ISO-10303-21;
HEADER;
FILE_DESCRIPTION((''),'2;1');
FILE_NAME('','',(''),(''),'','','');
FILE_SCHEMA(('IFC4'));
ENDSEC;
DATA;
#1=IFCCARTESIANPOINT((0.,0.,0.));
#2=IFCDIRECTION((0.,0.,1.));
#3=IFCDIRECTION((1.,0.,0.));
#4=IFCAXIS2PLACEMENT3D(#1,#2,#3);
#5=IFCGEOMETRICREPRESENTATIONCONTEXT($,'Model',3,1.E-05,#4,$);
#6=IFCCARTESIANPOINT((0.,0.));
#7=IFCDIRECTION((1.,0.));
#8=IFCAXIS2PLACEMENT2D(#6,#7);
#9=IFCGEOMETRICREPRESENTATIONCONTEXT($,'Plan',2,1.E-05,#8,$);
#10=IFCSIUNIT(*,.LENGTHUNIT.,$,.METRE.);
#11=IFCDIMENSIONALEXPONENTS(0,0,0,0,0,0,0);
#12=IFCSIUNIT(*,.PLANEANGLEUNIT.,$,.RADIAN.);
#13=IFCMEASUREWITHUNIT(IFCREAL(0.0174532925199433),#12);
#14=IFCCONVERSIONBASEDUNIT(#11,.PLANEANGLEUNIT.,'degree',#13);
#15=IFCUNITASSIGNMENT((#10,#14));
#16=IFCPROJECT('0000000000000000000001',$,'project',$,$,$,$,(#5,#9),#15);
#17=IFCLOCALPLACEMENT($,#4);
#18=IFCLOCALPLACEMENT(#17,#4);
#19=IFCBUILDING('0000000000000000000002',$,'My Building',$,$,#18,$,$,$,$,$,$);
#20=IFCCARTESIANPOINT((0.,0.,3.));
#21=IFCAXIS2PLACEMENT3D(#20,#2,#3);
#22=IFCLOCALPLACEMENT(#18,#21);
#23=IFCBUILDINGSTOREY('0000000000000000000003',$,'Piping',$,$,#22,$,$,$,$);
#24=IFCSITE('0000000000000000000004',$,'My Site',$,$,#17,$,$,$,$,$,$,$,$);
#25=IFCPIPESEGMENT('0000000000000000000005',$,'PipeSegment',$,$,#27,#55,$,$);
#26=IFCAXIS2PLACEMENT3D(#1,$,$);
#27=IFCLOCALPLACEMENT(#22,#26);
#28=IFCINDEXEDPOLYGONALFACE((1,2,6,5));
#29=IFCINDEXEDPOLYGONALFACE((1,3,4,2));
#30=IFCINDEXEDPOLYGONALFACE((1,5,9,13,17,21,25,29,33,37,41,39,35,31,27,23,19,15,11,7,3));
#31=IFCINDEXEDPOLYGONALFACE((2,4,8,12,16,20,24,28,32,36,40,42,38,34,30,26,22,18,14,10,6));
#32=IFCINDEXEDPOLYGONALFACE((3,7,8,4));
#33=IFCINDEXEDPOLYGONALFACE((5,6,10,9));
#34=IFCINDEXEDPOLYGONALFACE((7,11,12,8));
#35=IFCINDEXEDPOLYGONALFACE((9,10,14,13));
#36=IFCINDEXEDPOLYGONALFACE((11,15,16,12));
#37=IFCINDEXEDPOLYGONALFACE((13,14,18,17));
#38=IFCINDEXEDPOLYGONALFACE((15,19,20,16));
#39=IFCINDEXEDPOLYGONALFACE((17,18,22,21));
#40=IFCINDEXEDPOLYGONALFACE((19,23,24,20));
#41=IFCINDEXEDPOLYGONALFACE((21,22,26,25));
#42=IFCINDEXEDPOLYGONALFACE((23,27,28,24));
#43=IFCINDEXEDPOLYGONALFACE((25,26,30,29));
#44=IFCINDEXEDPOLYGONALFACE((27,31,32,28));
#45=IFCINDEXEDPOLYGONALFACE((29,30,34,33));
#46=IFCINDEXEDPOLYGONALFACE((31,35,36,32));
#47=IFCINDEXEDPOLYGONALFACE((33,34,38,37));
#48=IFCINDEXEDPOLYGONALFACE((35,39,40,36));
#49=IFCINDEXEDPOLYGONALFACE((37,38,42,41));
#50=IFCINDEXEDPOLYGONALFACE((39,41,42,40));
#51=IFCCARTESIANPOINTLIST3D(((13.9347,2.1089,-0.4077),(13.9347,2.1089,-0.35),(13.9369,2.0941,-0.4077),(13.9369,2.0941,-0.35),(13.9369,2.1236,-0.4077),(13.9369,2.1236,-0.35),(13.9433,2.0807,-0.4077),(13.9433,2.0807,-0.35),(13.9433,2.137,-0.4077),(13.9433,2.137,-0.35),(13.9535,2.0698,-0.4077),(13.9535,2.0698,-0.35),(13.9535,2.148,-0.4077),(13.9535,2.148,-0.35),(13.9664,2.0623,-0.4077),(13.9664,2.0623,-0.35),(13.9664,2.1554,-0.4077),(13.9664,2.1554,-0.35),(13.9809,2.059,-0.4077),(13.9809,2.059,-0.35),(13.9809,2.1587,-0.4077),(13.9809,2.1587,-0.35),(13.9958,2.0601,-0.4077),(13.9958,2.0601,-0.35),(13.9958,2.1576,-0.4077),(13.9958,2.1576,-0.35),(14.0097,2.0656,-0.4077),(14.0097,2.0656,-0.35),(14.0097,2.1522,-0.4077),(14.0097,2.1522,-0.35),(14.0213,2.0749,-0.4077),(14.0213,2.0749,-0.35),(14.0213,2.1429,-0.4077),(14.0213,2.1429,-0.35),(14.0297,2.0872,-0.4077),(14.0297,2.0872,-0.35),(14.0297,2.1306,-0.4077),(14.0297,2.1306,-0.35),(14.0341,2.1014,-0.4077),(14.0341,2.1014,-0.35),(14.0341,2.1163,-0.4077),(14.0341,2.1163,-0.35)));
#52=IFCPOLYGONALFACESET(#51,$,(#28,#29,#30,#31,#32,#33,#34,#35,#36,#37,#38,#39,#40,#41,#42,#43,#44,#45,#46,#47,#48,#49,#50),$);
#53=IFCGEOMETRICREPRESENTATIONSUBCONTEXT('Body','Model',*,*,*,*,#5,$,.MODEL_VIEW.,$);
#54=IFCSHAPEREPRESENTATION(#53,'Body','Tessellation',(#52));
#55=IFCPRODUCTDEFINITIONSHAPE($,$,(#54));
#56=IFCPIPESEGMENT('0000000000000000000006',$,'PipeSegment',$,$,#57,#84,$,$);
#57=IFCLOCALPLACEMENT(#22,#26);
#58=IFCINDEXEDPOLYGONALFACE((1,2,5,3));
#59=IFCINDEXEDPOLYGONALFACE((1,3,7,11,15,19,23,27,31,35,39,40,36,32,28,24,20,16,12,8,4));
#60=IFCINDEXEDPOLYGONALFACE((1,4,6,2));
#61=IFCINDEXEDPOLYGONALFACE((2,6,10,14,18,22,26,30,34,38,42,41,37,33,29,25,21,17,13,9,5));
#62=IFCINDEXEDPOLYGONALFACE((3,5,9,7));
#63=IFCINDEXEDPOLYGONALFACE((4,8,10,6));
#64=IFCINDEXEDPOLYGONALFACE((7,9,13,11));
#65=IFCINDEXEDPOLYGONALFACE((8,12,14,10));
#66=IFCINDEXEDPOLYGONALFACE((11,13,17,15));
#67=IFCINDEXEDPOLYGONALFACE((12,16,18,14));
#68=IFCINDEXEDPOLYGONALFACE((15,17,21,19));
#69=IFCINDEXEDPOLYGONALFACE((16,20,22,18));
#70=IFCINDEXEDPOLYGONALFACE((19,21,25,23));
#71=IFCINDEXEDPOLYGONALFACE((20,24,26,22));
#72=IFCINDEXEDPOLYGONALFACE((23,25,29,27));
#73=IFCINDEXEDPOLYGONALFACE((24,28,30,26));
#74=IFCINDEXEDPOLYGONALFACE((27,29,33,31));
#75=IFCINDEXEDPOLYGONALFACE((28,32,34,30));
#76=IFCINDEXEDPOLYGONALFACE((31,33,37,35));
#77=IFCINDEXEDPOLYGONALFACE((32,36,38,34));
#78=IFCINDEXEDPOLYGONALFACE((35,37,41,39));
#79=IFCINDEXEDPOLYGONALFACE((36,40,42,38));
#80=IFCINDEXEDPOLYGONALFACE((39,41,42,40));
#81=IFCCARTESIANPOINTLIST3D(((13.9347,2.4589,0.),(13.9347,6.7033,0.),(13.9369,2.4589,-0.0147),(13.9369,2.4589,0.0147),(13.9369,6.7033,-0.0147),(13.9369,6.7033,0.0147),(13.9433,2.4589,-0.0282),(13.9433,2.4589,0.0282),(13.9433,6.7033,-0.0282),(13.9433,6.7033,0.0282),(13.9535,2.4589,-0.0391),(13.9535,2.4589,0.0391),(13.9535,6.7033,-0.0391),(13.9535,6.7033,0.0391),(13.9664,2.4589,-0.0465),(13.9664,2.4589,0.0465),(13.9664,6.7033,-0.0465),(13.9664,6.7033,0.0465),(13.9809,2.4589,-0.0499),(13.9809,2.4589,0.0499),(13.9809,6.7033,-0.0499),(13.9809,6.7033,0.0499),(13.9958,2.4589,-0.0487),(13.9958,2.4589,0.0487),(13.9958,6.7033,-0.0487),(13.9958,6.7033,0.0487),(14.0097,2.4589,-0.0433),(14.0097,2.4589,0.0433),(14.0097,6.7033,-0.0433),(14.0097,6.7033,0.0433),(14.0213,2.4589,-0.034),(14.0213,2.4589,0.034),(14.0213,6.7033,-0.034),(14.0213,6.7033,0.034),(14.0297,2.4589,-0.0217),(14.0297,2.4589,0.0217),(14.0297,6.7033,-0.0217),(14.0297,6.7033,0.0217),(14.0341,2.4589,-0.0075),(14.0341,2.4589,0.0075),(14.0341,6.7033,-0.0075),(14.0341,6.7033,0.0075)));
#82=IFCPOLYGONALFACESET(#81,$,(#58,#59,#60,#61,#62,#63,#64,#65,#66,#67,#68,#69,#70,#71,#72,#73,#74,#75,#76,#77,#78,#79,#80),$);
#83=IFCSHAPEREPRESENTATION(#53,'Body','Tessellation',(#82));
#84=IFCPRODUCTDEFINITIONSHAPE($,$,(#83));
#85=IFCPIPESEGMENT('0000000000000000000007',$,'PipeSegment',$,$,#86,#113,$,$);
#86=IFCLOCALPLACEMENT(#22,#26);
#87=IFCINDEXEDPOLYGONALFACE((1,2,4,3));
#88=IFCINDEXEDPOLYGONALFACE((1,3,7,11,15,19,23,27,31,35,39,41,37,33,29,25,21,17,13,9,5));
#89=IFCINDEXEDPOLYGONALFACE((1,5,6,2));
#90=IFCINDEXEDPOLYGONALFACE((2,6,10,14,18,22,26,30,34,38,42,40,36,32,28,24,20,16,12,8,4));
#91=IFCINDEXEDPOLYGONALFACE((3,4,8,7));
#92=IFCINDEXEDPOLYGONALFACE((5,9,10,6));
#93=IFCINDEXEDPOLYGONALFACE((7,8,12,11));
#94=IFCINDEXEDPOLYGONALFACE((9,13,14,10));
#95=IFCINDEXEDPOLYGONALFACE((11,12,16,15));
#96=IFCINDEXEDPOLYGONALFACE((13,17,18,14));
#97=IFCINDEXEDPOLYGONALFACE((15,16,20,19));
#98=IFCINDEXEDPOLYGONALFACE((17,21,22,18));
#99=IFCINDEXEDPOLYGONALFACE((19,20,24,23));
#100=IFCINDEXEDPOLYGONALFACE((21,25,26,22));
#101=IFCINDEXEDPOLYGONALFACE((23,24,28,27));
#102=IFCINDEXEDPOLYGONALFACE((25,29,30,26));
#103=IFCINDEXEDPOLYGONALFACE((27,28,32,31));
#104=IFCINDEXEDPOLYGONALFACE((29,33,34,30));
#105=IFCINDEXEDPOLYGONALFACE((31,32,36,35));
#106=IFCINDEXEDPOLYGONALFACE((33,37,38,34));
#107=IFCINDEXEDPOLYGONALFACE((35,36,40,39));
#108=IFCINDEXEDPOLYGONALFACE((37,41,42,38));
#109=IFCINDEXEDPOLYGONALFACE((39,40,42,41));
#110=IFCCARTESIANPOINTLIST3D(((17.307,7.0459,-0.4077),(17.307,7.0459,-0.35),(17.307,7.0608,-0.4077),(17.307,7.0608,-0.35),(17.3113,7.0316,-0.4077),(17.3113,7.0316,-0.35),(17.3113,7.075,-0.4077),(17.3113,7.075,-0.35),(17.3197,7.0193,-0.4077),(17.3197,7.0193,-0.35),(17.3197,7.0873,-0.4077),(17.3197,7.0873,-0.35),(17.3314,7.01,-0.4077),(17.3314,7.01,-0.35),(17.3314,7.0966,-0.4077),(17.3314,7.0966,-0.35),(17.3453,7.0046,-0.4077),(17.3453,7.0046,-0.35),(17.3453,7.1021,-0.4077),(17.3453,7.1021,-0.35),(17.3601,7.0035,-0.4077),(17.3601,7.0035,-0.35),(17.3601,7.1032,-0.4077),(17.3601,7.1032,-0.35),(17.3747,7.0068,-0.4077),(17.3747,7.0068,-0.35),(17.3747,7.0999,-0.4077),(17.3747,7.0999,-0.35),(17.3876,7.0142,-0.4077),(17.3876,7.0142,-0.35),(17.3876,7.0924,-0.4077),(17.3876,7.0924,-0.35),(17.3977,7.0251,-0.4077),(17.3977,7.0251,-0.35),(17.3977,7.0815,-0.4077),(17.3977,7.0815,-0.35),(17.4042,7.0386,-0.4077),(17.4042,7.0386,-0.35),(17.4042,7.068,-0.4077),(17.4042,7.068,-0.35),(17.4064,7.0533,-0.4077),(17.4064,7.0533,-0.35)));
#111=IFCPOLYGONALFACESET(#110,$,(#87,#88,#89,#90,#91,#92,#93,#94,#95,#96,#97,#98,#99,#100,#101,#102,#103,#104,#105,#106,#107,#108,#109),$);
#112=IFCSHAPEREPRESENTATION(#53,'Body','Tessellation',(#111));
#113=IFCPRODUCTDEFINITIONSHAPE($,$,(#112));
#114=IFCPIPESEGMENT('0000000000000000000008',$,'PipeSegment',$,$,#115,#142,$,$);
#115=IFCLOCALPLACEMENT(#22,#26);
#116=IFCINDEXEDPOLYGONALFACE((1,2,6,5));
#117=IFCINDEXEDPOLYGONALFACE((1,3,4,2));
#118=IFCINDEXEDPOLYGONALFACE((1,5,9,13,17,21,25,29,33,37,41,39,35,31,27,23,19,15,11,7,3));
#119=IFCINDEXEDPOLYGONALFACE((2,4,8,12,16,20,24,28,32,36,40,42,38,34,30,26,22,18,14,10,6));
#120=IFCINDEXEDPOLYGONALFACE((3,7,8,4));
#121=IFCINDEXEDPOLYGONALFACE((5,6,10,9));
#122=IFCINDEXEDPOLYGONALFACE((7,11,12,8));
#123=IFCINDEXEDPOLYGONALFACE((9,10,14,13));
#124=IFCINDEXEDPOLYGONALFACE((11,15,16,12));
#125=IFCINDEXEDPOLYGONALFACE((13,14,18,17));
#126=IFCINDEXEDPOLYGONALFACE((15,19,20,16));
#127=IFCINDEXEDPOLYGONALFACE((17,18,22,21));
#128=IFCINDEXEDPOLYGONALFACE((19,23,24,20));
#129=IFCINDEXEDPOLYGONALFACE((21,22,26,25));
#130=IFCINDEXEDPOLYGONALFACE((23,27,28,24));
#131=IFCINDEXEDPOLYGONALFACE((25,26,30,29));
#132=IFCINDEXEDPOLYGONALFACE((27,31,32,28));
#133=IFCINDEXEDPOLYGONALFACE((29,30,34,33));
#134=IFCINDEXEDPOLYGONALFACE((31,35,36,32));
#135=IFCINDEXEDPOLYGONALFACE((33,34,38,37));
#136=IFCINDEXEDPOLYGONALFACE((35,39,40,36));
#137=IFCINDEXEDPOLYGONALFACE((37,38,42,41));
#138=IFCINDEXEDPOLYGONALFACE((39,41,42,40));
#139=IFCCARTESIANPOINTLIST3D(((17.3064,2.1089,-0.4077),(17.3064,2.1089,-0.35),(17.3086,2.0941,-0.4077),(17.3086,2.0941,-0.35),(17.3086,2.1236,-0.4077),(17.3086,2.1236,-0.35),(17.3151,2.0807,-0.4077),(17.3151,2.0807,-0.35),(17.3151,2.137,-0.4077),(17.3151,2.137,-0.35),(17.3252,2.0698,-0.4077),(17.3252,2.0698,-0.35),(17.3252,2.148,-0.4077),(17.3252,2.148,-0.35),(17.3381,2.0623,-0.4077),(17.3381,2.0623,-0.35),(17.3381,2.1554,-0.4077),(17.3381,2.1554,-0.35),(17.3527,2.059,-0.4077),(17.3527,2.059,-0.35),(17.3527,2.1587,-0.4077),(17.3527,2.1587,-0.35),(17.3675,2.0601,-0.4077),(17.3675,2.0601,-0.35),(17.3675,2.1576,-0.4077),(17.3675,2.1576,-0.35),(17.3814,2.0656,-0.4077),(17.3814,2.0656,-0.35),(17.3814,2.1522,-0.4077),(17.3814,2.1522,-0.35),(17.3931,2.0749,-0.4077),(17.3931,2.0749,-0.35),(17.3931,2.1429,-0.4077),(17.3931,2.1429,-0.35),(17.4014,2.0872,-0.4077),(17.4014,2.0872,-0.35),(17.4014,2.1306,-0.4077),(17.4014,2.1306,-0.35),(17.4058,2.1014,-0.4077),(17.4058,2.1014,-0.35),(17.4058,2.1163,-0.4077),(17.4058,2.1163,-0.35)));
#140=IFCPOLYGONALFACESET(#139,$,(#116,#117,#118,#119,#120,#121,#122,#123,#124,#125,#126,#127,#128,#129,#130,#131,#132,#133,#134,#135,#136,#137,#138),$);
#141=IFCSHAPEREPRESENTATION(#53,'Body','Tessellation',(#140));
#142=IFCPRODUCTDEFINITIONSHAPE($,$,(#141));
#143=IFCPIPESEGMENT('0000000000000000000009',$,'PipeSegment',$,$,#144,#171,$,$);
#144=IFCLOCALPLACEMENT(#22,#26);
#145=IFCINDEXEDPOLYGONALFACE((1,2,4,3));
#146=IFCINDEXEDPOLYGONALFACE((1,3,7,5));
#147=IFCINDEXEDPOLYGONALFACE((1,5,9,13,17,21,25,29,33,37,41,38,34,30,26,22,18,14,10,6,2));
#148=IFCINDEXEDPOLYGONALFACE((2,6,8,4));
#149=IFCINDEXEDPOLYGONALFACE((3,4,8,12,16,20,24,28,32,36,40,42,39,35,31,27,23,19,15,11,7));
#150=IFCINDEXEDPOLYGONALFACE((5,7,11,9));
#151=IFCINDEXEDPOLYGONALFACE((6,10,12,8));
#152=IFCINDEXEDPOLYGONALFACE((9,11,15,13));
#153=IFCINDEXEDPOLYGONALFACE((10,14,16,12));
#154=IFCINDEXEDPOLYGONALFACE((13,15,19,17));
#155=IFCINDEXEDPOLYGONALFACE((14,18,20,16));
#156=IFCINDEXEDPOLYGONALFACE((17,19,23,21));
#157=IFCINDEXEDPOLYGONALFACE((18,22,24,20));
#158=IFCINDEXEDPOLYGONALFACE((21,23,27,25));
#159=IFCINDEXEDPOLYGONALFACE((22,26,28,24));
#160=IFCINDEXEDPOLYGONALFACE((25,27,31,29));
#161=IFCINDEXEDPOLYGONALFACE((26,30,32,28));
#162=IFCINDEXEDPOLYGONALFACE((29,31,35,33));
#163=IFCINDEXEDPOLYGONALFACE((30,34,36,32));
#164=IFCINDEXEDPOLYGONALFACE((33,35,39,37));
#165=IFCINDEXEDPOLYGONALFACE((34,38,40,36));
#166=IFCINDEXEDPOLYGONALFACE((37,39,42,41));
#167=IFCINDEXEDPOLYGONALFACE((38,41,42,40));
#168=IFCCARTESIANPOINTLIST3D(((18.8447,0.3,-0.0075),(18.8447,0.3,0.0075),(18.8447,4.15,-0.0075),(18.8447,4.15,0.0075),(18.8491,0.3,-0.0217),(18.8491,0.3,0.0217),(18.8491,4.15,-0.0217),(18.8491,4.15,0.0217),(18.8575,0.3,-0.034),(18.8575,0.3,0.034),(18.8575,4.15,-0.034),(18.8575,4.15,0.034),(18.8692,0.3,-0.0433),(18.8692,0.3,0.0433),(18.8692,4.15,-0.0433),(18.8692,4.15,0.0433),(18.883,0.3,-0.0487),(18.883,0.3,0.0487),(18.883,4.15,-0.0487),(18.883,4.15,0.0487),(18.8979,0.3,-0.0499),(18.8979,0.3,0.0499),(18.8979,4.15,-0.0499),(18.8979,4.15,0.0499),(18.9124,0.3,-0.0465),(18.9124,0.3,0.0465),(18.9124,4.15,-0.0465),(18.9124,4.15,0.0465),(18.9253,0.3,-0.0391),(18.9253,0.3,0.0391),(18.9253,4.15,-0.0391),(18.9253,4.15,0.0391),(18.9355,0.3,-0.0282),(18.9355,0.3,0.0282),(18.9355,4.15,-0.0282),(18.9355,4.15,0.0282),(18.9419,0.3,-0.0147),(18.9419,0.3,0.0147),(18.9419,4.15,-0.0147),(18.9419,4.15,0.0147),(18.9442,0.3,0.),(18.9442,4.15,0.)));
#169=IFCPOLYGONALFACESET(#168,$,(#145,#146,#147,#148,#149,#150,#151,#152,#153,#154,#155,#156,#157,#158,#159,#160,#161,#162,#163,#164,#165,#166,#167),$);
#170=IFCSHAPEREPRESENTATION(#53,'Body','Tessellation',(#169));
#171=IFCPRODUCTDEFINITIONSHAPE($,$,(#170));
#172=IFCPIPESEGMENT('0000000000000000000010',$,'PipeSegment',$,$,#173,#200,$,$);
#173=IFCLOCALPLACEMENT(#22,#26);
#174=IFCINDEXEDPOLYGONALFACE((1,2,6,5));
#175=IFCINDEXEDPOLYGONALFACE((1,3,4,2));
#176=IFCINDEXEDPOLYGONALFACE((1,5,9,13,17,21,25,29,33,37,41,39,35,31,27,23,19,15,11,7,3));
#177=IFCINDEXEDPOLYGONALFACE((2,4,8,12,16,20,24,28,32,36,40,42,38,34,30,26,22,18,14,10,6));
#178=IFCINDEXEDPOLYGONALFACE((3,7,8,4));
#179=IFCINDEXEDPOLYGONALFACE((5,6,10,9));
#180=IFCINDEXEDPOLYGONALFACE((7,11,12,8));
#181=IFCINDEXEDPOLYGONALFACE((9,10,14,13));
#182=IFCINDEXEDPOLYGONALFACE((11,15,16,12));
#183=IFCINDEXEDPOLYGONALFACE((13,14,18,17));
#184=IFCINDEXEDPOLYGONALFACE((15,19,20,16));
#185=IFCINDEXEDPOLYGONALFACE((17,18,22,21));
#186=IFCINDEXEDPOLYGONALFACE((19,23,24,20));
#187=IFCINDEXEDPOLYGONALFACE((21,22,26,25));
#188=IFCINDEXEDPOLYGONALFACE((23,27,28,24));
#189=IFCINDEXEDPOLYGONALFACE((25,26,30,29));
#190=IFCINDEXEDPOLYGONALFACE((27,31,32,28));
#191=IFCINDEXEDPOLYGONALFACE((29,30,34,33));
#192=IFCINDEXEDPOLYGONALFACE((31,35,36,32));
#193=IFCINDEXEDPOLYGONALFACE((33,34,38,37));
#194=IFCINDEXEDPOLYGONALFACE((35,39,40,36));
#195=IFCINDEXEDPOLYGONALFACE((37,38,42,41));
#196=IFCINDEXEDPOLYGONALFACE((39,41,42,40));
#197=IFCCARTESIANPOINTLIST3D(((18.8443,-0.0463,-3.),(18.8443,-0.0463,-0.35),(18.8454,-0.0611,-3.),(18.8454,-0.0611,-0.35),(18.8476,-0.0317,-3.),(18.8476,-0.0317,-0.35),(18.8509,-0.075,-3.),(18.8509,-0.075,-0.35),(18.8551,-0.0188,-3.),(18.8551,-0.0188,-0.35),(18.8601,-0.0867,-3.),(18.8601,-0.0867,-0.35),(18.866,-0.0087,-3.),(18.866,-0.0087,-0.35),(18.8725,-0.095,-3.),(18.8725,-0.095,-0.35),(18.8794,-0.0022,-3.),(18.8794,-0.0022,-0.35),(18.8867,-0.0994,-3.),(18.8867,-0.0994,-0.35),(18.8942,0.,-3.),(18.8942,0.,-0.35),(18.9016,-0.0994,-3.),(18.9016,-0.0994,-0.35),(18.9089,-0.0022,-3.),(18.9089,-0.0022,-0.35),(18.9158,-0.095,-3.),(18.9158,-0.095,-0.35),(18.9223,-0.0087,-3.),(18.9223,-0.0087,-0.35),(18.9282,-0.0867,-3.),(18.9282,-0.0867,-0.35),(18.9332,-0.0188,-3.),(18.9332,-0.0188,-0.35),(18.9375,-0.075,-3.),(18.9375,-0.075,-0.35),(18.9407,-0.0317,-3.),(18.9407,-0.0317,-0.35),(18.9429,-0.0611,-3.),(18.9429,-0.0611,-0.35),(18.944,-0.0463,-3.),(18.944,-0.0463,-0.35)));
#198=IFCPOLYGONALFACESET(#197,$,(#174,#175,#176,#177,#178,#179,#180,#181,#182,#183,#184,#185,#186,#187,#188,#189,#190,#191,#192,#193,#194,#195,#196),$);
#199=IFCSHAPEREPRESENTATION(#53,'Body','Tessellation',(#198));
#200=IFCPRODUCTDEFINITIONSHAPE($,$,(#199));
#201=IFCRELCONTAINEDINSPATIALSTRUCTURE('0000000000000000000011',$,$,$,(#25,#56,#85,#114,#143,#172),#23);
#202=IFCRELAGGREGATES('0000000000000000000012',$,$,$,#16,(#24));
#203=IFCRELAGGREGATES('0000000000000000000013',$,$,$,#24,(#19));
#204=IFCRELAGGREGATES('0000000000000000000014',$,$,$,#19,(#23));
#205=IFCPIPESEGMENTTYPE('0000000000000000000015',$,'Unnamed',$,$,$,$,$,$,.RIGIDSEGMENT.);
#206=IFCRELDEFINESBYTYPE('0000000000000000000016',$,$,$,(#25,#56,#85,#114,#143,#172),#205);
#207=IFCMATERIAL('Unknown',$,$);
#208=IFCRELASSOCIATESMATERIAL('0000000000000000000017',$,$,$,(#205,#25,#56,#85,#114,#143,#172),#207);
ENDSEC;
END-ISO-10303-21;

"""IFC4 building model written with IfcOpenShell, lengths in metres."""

from ifc_helpers import new_model, entity, si_unit, converted_unit, frame, origin_with_axes, origin_2d_with_axis, place, context, subcontext, project, spatial, circle, extrude, material, material_profile, profile_set, profile_usage, type_object, element, save


model = new_model("IFC4")

# Units and contexts
model_context = context("Model", 3, precision=1e-05, world=origin_with_axes())
plan_context = context("Plan", 2, precision=1e-05, world=origin_2d_with_axis())
body_context = subcontext(model_context, "Body", "Model", "MODEL_VIEW")
ifc_project = project(units=[si_unit("LENGTHUNIT", "METRE"), converted_unit("PLANEANGLEUNIT", "degree", entity("IfcReal", 0.0174532925199433), si_unit("PLANEANGLEUNIT", "RADIAN"), dimensions=[0, 0, 0, 0, 0, 0, 0])], contexts=[model_context, plan_context])

# Site, building, storey
site_placement = place(None, origin_with_axes())
site = spatial("IfcSite", under=ifc_project, at=site_placement, Name="My Site")
building_placement = place(site_placement, origin_with_axes())
building = spatial("IfcBuilding", under=site, at=building_placement, Name="My Building")
storey_placement = place(building_placement, frame((0.0, 0.0, 3.0), z_axis=(0.0, 0.0, 1.0), x_axis=(1.0, 0.0, 0.0)))
storey = spatial("IfcBuildingStorey", under=building, at=storey_placement, Name="Piping")

# Pipe segments
ifc_material = material(Name="Unknown")
ifc_material_profile = material_profile(ifc_material, circle(Radius=0.05))
ifc_profile_set = profile_set([ifc_material_profile])
pipe_segment_type = type_object("IfcPipeSegmentType", Name="Unnamed", PredefinedType="RIGIDSEGMENT", material=ifc_profile_set)
ifc_profile_usage_1 = profile_usage(ifc_profile_set, cardinal=5)
pipe_segment_1_placement = place(storey_placement, frame((13.9847, 2.1089, -0.35), z_axis=(0.0, 0.0, -1.0), x_axis=(-1.0, 0.0, 0.0)))
element("IfcPipeSegment", 1, at=pipe_segment_1_placement, inside=storey, type_object=pipe_segment_type, material=ifc_profile_usage_1, Name="PipeSegment", context=body_context, shape_type="SweptSolid", body=[
    extrude(circle(Radius=0.05), origin_with_axes(), (0.0, 0.0, 1.0), 0.0577),
])
ifc_profile_usage_2 = profile_usage(ifc_profile_set, cardinal=5)
pipe_segment_2_placement = place(storey_placement, frame((13.9847, 2.4589, 0.0), z_axis=(0.0, 1.0, 0.0), x_axis=(-1.0, 0.0, 0.0)))
element("IfcPipeSegment", 2, at=pipe_segment_2_placement, inside=storey, type_object=pipe_segment_type, material=ifc_profile_usage_2, Name="PipeSegment", context=body_context, shape_type="SweptSolid", body=[
    extrude(circle(Radius=0.05), origin_with_axes(), (0.0, 0.0, 1.0), 4.2444),
])
ifc_profile_usage_3 = profile_usage(ifc_profile_set, cardinal=5)
pipe_segment_3_placement = place(storey_placement, frame((17.3564, 7.0533, -0.35), z_axis=(0.0, 0.0, -1.0), x_axis=(1.0, 0.0, 0.0)))
element("IfcPipeSegment", 3, at=pipe_segment_3_placement, inside=storey, type_object=pipe_segment_type, material=ifc_profile_usage_3, Name="PipeSegment", context=body_context, shape_type="SweptSolid", body=[
    extrude(circle(Radius=0.05), origin_with_axes(), (0.0, 0.0, 1.0), 0.0577),
])
ifc_profile_usage_4 = profile_usage(ifc_profile_set, cardinal=5)
pipe_segment_4_placement = place(storey_placement, frame((17.3564, 2.1089, -0.35), z_axis=(0.0, 0.0, -1.0), x_axis=(-1.0, 0.0, 0.0)))
element("IfcPipeSegment", 4, at=pipe_segment_4_placement, inside=storey, type_object=pipe_segment_type, material=ifc_profile_usage_4, Name="PipeSegment", context=body_context, shape_type="SweptSolid", body=[
    extrude(circle(Radius=0.05), origin_with_axes(), (0.0, 0.0, 1.0), 0.0577),
])
ifc_profile_usage_5 = profile_usage(ifc_profile_set, cardinal=5)
pipe_segment_5_placement = place(storey_placement, frame((18.8942, 4.15, 0.0), z_axis=(0.0, -1.0, 0.0), x_axis=(1.0, 0.0, 0.0)))
element("IfcPipeSegment", 5, at=pipe_segment_5_placement, inside=storey, type_object=pipe_segment_type, material=ifc_profile_usage_5, Name="PipeSegment", context=body_context, shape_type="SweptSolid", body=[
    extrude(circle(Radius=0.05), origin_with_axes(), (0.0, 0.0, 1.0), 3.85),
])
ifc_profile_usage_6 = profile_usage(ifc_profile_set, cardinal=5)
pipe_segment_6_placement = place(storey_placement, frame((18.8942, -0.05, -0.35), z_axis=(0.0, 0.0, -1.0), x_axis=(0.0, 1.0, 0.0)))
element("IfcPipeSegment", 6, at=pipe_segment_6_placement, inside=storey, type_object=pipe_segment_type, material=ifc_profile_usage_6, Name="PipeSegment", context=body_context, shape_type="SweptSolid", body=[
    extrude(circle(Radius=0.05), origin_with_axes(), (0.0, 0.0, 1.0), 2.65),
])

save(model, "model.ifc")
